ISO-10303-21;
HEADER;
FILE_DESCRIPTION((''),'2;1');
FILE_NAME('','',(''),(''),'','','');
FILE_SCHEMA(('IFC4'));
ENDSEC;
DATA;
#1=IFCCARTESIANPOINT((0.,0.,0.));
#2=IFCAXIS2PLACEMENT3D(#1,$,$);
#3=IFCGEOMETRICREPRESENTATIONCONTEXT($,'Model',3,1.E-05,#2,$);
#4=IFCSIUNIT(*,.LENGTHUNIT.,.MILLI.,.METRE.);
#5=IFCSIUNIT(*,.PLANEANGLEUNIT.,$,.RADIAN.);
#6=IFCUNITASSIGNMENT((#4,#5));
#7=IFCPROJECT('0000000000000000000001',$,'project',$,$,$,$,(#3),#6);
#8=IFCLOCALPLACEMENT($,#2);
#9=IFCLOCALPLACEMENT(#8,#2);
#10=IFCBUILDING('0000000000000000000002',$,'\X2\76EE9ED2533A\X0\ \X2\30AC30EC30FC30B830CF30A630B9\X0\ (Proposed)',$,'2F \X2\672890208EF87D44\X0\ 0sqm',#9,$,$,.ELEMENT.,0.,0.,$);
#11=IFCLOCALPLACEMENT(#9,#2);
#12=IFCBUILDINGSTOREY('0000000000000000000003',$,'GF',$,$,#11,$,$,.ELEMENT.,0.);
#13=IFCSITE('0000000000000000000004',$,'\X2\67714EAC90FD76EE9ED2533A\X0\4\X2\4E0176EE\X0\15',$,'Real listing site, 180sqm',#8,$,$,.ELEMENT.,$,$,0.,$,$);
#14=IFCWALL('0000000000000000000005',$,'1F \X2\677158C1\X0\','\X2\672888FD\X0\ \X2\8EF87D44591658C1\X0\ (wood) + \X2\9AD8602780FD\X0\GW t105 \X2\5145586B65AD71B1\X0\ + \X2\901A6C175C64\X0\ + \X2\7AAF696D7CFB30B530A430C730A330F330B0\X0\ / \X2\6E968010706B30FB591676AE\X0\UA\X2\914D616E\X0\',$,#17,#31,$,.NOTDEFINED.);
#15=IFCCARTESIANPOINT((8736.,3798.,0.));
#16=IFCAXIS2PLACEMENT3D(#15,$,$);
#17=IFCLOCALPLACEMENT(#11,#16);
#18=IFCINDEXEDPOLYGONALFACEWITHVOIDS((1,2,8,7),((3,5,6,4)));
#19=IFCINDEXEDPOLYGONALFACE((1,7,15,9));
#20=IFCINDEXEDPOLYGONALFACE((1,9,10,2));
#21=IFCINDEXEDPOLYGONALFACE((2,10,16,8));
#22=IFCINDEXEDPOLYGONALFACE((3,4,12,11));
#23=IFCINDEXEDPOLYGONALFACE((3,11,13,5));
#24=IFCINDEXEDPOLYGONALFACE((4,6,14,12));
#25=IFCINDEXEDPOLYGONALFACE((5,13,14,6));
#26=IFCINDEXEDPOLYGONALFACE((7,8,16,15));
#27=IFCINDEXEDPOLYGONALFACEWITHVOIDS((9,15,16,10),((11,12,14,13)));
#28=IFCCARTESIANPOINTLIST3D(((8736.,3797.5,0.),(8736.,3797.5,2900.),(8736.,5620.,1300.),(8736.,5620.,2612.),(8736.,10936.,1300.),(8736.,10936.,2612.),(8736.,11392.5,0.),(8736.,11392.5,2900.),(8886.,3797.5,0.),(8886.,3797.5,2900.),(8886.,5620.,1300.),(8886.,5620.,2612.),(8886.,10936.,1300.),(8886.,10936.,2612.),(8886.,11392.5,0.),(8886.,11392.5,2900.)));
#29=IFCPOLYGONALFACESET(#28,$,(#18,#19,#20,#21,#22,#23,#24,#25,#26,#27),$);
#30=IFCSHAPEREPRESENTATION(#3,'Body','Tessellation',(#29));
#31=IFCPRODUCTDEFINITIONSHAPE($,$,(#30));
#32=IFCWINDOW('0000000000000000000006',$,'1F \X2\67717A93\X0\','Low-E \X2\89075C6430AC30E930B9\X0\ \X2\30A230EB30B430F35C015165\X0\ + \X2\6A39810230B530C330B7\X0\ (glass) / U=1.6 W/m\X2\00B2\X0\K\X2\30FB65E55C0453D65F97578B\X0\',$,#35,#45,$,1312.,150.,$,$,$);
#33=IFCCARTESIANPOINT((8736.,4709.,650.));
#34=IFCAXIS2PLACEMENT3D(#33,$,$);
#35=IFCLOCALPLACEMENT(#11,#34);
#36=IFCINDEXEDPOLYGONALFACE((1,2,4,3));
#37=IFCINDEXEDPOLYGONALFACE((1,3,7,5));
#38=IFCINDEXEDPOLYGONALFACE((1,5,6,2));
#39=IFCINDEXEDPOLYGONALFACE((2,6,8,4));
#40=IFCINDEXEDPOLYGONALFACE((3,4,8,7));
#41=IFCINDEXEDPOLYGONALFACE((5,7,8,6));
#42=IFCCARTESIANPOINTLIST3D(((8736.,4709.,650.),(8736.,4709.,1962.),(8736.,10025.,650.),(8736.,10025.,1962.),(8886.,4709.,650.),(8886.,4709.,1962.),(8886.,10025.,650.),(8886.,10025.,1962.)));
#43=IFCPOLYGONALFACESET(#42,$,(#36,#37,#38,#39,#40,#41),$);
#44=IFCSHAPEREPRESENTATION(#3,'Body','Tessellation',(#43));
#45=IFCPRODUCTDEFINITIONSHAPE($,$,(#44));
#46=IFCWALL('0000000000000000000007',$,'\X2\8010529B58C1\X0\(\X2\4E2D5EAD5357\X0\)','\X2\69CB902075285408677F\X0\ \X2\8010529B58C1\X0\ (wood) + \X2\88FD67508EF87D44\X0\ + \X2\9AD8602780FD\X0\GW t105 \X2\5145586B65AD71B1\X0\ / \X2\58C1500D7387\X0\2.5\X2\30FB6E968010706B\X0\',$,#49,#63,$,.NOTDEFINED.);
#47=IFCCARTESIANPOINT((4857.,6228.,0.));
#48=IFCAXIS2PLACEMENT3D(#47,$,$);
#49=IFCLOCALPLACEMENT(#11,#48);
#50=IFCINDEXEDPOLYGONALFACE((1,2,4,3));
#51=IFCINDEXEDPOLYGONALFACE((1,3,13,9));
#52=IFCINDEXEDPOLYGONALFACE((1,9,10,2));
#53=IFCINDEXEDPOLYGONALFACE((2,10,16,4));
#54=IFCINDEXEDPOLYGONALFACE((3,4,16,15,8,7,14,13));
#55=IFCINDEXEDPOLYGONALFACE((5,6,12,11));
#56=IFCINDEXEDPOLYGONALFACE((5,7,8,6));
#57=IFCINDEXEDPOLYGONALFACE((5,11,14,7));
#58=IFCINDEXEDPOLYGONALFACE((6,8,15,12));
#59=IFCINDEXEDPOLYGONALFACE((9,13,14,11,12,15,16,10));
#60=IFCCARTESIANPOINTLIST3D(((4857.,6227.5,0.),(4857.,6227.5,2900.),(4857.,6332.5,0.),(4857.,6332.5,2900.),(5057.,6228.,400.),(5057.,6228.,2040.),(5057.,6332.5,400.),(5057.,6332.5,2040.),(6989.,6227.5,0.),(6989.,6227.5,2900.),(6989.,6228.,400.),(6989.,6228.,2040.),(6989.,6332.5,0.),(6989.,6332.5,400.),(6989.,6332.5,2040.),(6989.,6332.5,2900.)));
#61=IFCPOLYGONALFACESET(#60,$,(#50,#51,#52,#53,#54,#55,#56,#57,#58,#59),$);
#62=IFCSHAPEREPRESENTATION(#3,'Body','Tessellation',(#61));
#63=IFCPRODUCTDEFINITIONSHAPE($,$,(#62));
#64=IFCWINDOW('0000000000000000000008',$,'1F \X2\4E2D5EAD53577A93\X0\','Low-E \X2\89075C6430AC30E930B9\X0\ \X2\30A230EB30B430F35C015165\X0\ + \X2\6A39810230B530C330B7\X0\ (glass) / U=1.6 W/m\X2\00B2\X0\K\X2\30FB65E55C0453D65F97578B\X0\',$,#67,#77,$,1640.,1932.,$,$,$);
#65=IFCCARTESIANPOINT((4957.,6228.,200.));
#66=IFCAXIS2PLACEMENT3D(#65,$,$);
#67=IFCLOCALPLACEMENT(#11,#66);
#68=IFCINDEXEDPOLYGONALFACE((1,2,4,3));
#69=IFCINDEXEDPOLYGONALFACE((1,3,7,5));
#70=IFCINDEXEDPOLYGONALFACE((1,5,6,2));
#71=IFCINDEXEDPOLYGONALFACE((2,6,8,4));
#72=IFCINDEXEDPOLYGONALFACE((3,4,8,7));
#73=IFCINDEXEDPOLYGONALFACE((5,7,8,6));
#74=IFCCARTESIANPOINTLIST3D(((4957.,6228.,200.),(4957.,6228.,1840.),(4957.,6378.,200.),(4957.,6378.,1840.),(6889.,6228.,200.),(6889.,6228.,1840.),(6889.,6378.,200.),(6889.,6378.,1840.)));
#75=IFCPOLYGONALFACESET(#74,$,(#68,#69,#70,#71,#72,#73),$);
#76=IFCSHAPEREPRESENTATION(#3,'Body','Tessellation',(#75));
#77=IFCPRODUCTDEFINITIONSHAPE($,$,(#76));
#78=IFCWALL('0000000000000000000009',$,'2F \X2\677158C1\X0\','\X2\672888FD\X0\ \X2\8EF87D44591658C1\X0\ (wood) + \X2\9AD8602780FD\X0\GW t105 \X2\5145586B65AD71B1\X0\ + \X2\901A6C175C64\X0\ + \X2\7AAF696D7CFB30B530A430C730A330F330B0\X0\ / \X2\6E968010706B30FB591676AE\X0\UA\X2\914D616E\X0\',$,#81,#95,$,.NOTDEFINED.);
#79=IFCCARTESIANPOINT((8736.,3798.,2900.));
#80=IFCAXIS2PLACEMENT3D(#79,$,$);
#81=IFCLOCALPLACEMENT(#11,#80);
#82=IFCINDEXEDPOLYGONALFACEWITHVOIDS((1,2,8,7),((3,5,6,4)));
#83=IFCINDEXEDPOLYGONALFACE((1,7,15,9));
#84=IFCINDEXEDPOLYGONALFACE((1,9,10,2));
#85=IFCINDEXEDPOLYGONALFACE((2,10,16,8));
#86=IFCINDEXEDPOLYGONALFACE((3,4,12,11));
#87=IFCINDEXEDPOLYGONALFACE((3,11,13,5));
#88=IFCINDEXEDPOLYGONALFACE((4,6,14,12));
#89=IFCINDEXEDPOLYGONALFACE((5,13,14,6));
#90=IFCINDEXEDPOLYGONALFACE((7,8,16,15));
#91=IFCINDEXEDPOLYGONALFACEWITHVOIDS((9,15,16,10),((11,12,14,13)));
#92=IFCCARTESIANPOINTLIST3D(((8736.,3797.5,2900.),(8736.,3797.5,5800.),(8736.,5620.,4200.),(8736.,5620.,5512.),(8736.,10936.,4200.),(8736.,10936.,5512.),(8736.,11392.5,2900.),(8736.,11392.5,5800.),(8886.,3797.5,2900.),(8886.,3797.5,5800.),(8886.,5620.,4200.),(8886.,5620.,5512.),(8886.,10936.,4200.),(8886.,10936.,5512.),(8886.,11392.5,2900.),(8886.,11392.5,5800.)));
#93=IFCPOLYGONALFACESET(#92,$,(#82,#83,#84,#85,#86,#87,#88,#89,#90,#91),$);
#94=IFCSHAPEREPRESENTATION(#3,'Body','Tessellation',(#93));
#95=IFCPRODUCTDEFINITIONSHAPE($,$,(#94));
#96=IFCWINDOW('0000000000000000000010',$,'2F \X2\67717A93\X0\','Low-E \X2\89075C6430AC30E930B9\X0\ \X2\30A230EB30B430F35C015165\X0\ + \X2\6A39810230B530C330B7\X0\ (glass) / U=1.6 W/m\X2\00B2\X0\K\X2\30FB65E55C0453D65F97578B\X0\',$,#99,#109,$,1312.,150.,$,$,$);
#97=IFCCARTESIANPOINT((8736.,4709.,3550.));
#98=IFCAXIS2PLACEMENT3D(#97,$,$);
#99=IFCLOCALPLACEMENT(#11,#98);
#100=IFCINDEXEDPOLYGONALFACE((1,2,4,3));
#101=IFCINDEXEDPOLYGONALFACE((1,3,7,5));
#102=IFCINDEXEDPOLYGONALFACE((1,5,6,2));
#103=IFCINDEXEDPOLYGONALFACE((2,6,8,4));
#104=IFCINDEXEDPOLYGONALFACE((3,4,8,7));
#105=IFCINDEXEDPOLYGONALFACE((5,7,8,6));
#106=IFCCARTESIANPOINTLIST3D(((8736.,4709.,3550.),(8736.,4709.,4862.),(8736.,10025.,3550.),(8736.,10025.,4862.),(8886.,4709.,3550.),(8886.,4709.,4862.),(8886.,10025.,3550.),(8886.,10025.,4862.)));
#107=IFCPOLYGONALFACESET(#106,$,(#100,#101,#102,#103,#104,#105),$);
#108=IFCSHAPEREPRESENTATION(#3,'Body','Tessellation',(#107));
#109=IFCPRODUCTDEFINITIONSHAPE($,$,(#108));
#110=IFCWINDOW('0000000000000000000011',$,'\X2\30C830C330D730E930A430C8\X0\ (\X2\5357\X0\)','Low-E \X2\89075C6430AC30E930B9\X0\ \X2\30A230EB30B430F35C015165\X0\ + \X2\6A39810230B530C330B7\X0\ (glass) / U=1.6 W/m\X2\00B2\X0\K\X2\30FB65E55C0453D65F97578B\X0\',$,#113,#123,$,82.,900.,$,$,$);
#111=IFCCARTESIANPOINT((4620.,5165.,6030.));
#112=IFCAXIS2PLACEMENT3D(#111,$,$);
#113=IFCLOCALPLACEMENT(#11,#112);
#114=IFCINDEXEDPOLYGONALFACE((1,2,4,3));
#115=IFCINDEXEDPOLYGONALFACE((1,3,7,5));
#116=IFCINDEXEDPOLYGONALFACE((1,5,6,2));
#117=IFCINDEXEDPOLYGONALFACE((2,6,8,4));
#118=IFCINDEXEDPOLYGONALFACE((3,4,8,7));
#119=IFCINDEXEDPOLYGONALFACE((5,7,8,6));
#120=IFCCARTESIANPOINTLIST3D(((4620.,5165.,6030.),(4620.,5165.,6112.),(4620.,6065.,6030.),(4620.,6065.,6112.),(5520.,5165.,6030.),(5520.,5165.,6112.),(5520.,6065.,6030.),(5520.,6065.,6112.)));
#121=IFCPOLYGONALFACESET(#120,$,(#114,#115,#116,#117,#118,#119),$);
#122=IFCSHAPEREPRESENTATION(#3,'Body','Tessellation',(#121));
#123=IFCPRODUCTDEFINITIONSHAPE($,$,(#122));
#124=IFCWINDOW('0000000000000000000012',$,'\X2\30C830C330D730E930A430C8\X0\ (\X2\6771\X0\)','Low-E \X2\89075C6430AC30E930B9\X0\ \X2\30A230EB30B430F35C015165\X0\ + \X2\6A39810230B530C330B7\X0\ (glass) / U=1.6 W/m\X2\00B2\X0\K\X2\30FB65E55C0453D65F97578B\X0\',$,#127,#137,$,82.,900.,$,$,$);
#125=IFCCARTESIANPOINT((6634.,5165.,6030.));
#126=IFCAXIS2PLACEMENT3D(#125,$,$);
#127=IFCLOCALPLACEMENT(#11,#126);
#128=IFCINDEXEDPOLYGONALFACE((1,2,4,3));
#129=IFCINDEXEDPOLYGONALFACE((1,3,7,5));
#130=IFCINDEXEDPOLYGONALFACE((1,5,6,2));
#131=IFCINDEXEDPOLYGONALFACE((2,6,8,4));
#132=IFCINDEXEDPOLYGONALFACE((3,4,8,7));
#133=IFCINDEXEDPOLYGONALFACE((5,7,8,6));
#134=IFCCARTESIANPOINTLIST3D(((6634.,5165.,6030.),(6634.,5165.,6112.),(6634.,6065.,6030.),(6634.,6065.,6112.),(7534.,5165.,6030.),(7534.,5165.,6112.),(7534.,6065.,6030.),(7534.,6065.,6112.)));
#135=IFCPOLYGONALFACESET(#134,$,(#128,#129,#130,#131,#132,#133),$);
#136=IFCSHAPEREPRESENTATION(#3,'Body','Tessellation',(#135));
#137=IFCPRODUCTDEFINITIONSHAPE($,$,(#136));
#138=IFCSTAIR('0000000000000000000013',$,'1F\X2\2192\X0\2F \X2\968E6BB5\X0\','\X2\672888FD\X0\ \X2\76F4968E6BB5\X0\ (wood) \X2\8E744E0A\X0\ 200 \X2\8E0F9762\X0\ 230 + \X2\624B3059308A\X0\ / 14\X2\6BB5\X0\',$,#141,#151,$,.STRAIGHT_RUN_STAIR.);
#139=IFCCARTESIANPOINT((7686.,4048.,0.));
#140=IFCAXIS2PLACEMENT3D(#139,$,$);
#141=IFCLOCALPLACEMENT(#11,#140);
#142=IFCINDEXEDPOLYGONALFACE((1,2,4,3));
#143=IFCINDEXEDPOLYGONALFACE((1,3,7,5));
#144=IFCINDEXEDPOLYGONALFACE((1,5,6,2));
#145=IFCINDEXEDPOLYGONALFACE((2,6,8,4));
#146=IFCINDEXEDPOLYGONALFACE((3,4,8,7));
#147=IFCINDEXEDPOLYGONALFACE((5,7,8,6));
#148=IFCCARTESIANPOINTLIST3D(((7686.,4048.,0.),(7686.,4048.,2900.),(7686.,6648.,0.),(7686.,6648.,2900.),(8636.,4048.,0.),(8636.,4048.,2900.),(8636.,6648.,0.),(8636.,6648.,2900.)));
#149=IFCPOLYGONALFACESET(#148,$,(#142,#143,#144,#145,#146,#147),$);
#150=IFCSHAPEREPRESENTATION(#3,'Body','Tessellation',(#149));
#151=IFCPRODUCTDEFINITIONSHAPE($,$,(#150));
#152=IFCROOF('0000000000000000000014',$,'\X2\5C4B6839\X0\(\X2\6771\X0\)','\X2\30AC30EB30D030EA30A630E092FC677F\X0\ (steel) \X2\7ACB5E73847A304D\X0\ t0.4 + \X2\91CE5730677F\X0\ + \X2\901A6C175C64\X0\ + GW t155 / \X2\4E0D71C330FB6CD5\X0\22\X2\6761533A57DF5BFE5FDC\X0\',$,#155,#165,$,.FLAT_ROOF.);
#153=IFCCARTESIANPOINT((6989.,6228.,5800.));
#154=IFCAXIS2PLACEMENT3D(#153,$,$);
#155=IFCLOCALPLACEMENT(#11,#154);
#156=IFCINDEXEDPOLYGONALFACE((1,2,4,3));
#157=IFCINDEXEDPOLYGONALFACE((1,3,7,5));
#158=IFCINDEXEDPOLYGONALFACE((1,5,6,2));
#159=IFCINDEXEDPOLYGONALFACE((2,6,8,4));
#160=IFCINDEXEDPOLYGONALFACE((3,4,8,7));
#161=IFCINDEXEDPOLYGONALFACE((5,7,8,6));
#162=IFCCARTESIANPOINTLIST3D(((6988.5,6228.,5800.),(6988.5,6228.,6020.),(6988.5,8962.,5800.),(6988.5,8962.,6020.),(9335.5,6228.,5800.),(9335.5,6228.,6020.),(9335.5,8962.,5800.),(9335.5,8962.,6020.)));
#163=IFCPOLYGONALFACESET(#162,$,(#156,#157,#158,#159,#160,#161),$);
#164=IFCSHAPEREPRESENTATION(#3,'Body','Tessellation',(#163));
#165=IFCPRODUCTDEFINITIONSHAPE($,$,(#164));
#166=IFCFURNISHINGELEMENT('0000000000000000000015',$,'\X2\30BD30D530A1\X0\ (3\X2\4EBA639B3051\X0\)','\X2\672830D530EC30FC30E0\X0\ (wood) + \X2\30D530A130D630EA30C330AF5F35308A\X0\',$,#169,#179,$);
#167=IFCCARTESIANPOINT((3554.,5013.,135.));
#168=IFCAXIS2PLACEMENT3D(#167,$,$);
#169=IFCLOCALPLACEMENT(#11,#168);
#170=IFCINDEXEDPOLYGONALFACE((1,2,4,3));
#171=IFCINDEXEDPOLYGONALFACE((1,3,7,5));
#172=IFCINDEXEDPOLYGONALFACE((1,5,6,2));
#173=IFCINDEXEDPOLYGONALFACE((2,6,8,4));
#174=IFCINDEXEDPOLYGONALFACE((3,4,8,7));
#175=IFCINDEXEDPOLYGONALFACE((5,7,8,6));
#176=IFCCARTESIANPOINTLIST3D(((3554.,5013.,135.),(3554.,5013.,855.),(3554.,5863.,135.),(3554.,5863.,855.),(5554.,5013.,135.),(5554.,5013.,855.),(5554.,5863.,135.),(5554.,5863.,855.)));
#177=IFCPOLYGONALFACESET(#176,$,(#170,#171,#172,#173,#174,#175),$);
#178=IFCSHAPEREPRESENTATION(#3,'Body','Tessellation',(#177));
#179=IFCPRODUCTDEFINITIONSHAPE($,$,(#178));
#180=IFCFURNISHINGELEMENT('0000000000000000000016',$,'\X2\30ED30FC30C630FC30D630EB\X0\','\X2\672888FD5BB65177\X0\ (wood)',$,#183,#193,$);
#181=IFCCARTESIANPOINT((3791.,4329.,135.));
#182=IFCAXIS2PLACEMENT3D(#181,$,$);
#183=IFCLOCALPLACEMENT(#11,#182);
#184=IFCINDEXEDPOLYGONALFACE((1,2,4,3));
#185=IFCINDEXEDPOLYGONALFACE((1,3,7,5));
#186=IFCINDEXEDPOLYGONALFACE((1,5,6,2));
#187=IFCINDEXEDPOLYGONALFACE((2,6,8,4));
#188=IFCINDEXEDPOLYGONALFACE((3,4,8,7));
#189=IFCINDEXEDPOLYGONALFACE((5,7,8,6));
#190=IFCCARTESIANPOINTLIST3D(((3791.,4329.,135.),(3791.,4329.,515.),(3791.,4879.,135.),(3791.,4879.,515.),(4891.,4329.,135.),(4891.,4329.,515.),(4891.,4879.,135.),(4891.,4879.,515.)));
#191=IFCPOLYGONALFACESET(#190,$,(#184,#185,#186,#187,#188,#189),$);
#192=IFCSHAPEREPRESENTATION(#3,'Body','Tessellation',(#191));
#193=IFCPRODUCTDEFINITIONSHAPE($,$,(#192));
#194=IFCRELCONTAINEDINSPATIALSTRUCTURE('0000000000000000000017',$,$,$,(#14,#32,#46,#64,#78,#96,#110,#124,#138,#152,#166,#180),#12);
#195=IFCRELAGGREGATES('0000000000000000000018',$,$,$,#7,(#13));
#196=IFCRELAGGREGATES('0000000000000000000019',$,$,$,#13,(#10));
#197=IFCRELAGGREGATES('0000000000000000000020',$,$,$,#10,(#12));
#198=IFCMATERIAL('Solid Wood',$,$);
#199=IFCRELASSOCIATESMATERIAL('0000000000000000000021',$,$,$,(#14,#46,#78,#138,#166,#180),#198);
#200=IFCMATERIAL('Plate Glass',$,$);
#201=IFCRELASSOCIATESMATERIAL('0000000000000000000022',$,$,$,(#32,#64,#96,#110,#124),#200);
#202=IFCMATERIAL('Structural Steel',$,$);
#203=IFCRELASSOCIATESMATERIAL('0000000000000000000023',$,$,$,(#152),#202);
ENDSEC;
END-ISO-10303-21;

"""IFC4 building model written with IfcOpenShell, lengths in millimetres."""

from ifc_helpers import new_model, si_unit, frame, frame_2d, origin, place, context, project, spatial, rectangle, extrude, material, element, fill, save


model = new_model("IFC4")

# Units and contexts
model_context = context("Model", 3, precision=1e-05, world=origin())
ifc_project = project(units=[si_unit("LENGTHUNIT", "METRE", prefix="MILLI"), si_unit("PLANEANGLEUNIT", "RADIAN")], contexts=[model_context])

# Site, building, storey
site_placement = place(None, origin())
site = spatial("IfcSite", under=ifc_project, at=site_placement, Name="東京都目黒区4丁目15", ObjectType="Real listing site, 180sqm", CompositionType="ELEMENT", RefElevation=0.0)
building_placement = place(site_placement, origin())
building = spatial("IfcBuilding", under=site, at=building_placement, Name="目黒区 ガレージハウス (Proposed)", ObjectType="2F 木造軸組 0sqm", CompositionType="ELEMENT", ElevationOfRefHeight=0.0, ElevationOfTerrain=0.0)
storey_placement = place(building_placement, origin())
storey = spatial("IfcBuildingStorey", under=building, at=storey_placement, Name="GF", CompositionType="ELEMENT", Elevation=0.0)

# Shared definitions
ifc_material_1 = material(Name="Solid Wood")

# Walls, openings, windows
wall_1_placement = place(storey_placement, frame((8736.0, 3798.0, 0.0)))
wall_1 = element("IfcWall", 1, at=wall_1_placement, inside=storey, material=ifc_material_1, Name="1F 東壁", Description="木製 軸組外壁 (wood) + 高性能GW t105 充填断熱 + 通気層 + 窯業系サイディング / 準耐火・外皮UA配慮", PredefinedType="NOTDEFINED", context=model_context, shape_type="SweptSolid", body=[
    extrude(rectangle(XDim=150.0, YDim=7595.0, at=frame_2d((75.0, 3797.0))), frame((8736.0, 3798.0, 0.0)), (0.0, 0.0, 1.0), 2900.0),
])
opening_1_placement = place(storey_placement, frame((8736.0, 4709.0, 650.0)))
opening_1 = element("IfcOpeningElement", 2, at=opening_1_placement, cuts=wall_1, PredefinedType="NOTDEFINED", context=model_context, shape_type="SweptSolid", body=[
    extrude(rectangle(XDim=150.0, YDim=5316.0, at=frame_2d((75.0, 2658.0))), frame((8736.0, 4709.0, 650.0)), (0.0, 0.0, 1.0), 1312.0),
])
ifc_material_2 = material(Name="Plate Glass")
window_1_placement = place(storey_placement, frame((8736.0, 4709.0, 650.0)))
window_1 = element("IfcWindow", 3, at=window_1_placement, inside=storey, material=ifc_material_2, Name="1F 東窓", Description="Low-E 複層ガラス アルゴン封入 + 樹脂サッシ (glass) / U=1.6 W/m²K・日射取得型", OverallHeight=1312.0, OverallWidth=150.0, context=model_context, shape_type="SweptSolid", body=[
    extrude(rectangle(XDim=150.0, YDim=5316.0, at=frame_2d((75.0, 2658.0))), frame((8736.0, 4709.0, 650.0)), (0.0, 0.0, 1.0), 1312.0),
])
fill(opening_1, window_1)
wall_2_placement = place(storey_placement, frame((4857.0, 6228.0, 0.0)))
wall_2 = element("IfcWall", 4, at=wall_2_placement, inside=storey, material=ifc_material_1, Name="耐力壁(中庭南)", Description="構造用合板 耐力壁 (wood) + 製材軸組 + 高性能GW t105 充填断熱 / 壁倍率2.5・準耐火", PredefinedType="NOTDEFINED", context=model_context, shape_type="SweptSolid", body=[
    extrude(rectangle(XDim=2132.0, YDim=105.0, at=frame_2d((1066.0, 52.0))), frame((4857.0, 6228.0, 0.0)), (0.0, 0.0, 1.0), 2900.0),
])
opening_2_placement = place(storey_placement, frame((4957.0, 6228.0, 200.0)))
opening_2 = element("IfcOpeningElement", 5, at=opening_2_placement, cuts=wall_2, PredefinedType="NOTDEFINED", context=model_context, shape_type="SweptSolid", body=[
    extrude(rectangle(XDim=1932.0, YDim=150.0, at=frame_2d((966.0, 75.0))), frame((4957.0, 6228.0, 200.0)), (0.0, 0.0, 1.0), 1640.0),
])
window_2_placement = place(storey_placement, frame((4957.0, 6228.0, 200.0)))
window_2 = element("IfcWindow", 6, at=window_2_placement, inside=storey, material=ifc_material_2, Name="1F 中庭南窓", Description="Low-E 複層ガラス アルゴン封入 + 樹脂サッシ (glass) / U=1.6 W/m²K・日射取得型", OverallHeight=1640.0, OverallWidth=1932.0, context=model_context, shape_type="SweptSolid", body=[
    extrude(rectangle(XDim=1932.0, YDim=150.0, at=frame_2d((966.0, 75.0))), frame((4957.0, 6228.0, 200.0)), (0.0, 0.0, 1.0), 1640.0),
])
fill(opening_2, window_2)

# Wall, opening, window
wall_3_placement = place(storey_placement, frame((8736.0, 3798.0, 2900.0)))
wall_3 = element("IfcWall", 7, at=wall_3_placement, inside=storey, material=ifc_material_1, Name="2F 東壁", Description="木製 軸組外壁 (wood) + 高性能GW t105 充填断熱 + 通気層 + 窯業系サイディング / 準耐火・外皮UA配慮", PredefinedType="NOTDEFINED", context=model_context, shape_type="SweptSolid", body=[
    extrude(rectangle(XDim=150.0, YDim=7595.0, at=frame_2d((75.0, 3797.0))), frame((8736.0, 3798.0, 2900.0)), (0.0, 0.0, 1.0), 2900.0),
])
opening_3_placement = place(storey_placement, frame((8736.0, 4709.0, 3550.0)))
opening_3 = element("IfcOpeningElement", 8, at=opening_3_placement, cuts=wall_3, PredefinedType="NOTDEFINED", context=model_context, shape_type="SweptSolid", body=[
    extrude(rectangle(XDim=150.0, YDim=5316.0, at=frame_2d((75.0, 2658.0))), frame((8736.0, 4709.0, 3550.0)), (0.0, 0.0, 1.0), 1312.0),
])
window_3_placement = place(storey_placement, frame((8736.0, 4709.0, 3550.0)))
window_3 = element("IfcWindow", 9, at=window_3_placement, inside=storey, material=ifc_material_2, Name="2F 東窓", Description="Low-E 複層ガラス アルゴン封入 + 樹脂サッシ (glass) / U=1.6 W/m²K・日射取得型", OverallHeight=1312.0, OverallWidth=150.0, context=model_context, shape_type="SweptSolid", body=[
    extrude(rectangle(XDim=150.0, YDim=5316.0, at=frame_2d((75.0, 2658.0))), frame((8736.0, 4709.0, 3550.0)), (0.0, 0.0, 1.0), 1312.0),
])
fill(opening_3, window_3)

# Windows
window_4_placement = place(storey_placement, frame((4620.0, 5165.0, 6030.0)))
element("IfcWindow", 10, at=window_4_placement, inside=storey, material=ifc_material_2, Name="トップライト (南)", Description="Low-E 複層ガラス アルゴン封入 + 樹脂サッシ (glass) / U=1.6 W/m²K・日射取得型", OverallHeight=82.0, OverallWidth=900.0, context=model_context, shape_type="SweptSolid", body=[
    extrude(rectangle(XDim=900.0, YDim=900.0, at=frame_2d((450.0, 450.0))), frame((4620.0, 5165.0, 6030.0)), (0.0, 0.0, 1.0), 82.0),
])
window_5_placement = place(storey_placement, frame((6634.0, 5165.0, 6030.0)))
element("IfcWindow", 11, at=window_5_placement, inside=storey, material=ifc_material_2, Name="トップライト (東)", Description="Low-E 複層ガラス アルゴン封入 + 樹脂サッシ (glass) / U=1.6 W/m²K・日射取得型", OverallHeight=82.0, OverallWidth=900.0, context=model_context, shape_type="SweptSolid", body=[
    extrude(rectangle(XDim=900.0, YDim=900.0, at=frame_2d((450.0, 450.0))), frame((6634.0, 5165.0, 6030.0)), (0.0, 0.0, 1.0), 82.0),
])

# Stair
stair_placement = place(storey_placement, frame((7686.0, 4048.0, 0.0)))
element("IfcStair", 12, at=stair_placement, inside=storey, material=ifc_material_1, Name="1F→2F 階段", Description="木製 直階段 (wood) 蹴上 200 踏面 230 + 手すり / 14段", PredefinedType="STRAIGHT_RUN_STAIR", context=model_context, shape_type="SweptSolid", body=[
    extrude(rectangle(XDim=950.0, YDim=2600.0, at=frame_2d((475.0, 1300.0))), frame((7686.0, 4048.0, 0.0)), (0.0, 0.0, 1.0), 2900.0),
])

# Roof
ifc_material_3 = material(Name="Structural Steel")
roof_placement = place(storey_placement, frame((6989.0, 6228.0, 5800.0)))
element("IfcRoof", 13, at=roof_placement, inside=storey, material=ifc_material_3, Name="屋根(東)", Description="ガルバリウム鋼板 (steel) 立平葺き t0.4 + 野地板 + 通気層 + GW t155 / 不燃・法22条区域対応", PredefinedType="FLAT_ROOF", context=model_context, shape_type="SweptSolid", body=[
    extrude(rectangle(XDim=2347.0, YDim=2734.0, at=frame_2d((1173.0, 1367.0))), frame((6989.0, 6228.0, 5800.0)), (0.0, 0.0, 1.0), 220.0),
])

# Furnishing elements
furnishing_1_placement = place(storey_placement, frame((3554.0, 5013.0, 135.0)))
element("IfcFurnishingElement", 14, at=furnishing_1_placement, inside=storey, material=ifc_material_1, Name="ソファ (3人掛け)", Description="木フレーム (wood) + ファブリック張り", context=model_context, shape_type="SweptSolid", body=[
    extrude(rectangle(XDim=2000.0, YDim=850.0, at=frame_2d((1000.0, 425.0))), frame((3554.0, 5013.0, 135.0)), (0.0, 0.0, 1.0), 720.0),
])
furnishing_2_placement = place(storey_placement, frame((3791.0, 4329.0, 135.0)))
element("IfcFurnishingElement", 15, at=furnishing_2_placement, inside=storey, material=ifc_material_1, Name="ローテーブル", Description="木製家具 (wood)", context=model_context, shape_type="SweptSolid", body=[
    extrude(rectangle(XDim=1100.0, YDim=550.0, at=frame_2d((550.0, 275.0))), frame((3791.0, 4329.0, 135.0)), (0.0, 0.0, 1.0), 380.0),
])

save(model, "model.ifc")
